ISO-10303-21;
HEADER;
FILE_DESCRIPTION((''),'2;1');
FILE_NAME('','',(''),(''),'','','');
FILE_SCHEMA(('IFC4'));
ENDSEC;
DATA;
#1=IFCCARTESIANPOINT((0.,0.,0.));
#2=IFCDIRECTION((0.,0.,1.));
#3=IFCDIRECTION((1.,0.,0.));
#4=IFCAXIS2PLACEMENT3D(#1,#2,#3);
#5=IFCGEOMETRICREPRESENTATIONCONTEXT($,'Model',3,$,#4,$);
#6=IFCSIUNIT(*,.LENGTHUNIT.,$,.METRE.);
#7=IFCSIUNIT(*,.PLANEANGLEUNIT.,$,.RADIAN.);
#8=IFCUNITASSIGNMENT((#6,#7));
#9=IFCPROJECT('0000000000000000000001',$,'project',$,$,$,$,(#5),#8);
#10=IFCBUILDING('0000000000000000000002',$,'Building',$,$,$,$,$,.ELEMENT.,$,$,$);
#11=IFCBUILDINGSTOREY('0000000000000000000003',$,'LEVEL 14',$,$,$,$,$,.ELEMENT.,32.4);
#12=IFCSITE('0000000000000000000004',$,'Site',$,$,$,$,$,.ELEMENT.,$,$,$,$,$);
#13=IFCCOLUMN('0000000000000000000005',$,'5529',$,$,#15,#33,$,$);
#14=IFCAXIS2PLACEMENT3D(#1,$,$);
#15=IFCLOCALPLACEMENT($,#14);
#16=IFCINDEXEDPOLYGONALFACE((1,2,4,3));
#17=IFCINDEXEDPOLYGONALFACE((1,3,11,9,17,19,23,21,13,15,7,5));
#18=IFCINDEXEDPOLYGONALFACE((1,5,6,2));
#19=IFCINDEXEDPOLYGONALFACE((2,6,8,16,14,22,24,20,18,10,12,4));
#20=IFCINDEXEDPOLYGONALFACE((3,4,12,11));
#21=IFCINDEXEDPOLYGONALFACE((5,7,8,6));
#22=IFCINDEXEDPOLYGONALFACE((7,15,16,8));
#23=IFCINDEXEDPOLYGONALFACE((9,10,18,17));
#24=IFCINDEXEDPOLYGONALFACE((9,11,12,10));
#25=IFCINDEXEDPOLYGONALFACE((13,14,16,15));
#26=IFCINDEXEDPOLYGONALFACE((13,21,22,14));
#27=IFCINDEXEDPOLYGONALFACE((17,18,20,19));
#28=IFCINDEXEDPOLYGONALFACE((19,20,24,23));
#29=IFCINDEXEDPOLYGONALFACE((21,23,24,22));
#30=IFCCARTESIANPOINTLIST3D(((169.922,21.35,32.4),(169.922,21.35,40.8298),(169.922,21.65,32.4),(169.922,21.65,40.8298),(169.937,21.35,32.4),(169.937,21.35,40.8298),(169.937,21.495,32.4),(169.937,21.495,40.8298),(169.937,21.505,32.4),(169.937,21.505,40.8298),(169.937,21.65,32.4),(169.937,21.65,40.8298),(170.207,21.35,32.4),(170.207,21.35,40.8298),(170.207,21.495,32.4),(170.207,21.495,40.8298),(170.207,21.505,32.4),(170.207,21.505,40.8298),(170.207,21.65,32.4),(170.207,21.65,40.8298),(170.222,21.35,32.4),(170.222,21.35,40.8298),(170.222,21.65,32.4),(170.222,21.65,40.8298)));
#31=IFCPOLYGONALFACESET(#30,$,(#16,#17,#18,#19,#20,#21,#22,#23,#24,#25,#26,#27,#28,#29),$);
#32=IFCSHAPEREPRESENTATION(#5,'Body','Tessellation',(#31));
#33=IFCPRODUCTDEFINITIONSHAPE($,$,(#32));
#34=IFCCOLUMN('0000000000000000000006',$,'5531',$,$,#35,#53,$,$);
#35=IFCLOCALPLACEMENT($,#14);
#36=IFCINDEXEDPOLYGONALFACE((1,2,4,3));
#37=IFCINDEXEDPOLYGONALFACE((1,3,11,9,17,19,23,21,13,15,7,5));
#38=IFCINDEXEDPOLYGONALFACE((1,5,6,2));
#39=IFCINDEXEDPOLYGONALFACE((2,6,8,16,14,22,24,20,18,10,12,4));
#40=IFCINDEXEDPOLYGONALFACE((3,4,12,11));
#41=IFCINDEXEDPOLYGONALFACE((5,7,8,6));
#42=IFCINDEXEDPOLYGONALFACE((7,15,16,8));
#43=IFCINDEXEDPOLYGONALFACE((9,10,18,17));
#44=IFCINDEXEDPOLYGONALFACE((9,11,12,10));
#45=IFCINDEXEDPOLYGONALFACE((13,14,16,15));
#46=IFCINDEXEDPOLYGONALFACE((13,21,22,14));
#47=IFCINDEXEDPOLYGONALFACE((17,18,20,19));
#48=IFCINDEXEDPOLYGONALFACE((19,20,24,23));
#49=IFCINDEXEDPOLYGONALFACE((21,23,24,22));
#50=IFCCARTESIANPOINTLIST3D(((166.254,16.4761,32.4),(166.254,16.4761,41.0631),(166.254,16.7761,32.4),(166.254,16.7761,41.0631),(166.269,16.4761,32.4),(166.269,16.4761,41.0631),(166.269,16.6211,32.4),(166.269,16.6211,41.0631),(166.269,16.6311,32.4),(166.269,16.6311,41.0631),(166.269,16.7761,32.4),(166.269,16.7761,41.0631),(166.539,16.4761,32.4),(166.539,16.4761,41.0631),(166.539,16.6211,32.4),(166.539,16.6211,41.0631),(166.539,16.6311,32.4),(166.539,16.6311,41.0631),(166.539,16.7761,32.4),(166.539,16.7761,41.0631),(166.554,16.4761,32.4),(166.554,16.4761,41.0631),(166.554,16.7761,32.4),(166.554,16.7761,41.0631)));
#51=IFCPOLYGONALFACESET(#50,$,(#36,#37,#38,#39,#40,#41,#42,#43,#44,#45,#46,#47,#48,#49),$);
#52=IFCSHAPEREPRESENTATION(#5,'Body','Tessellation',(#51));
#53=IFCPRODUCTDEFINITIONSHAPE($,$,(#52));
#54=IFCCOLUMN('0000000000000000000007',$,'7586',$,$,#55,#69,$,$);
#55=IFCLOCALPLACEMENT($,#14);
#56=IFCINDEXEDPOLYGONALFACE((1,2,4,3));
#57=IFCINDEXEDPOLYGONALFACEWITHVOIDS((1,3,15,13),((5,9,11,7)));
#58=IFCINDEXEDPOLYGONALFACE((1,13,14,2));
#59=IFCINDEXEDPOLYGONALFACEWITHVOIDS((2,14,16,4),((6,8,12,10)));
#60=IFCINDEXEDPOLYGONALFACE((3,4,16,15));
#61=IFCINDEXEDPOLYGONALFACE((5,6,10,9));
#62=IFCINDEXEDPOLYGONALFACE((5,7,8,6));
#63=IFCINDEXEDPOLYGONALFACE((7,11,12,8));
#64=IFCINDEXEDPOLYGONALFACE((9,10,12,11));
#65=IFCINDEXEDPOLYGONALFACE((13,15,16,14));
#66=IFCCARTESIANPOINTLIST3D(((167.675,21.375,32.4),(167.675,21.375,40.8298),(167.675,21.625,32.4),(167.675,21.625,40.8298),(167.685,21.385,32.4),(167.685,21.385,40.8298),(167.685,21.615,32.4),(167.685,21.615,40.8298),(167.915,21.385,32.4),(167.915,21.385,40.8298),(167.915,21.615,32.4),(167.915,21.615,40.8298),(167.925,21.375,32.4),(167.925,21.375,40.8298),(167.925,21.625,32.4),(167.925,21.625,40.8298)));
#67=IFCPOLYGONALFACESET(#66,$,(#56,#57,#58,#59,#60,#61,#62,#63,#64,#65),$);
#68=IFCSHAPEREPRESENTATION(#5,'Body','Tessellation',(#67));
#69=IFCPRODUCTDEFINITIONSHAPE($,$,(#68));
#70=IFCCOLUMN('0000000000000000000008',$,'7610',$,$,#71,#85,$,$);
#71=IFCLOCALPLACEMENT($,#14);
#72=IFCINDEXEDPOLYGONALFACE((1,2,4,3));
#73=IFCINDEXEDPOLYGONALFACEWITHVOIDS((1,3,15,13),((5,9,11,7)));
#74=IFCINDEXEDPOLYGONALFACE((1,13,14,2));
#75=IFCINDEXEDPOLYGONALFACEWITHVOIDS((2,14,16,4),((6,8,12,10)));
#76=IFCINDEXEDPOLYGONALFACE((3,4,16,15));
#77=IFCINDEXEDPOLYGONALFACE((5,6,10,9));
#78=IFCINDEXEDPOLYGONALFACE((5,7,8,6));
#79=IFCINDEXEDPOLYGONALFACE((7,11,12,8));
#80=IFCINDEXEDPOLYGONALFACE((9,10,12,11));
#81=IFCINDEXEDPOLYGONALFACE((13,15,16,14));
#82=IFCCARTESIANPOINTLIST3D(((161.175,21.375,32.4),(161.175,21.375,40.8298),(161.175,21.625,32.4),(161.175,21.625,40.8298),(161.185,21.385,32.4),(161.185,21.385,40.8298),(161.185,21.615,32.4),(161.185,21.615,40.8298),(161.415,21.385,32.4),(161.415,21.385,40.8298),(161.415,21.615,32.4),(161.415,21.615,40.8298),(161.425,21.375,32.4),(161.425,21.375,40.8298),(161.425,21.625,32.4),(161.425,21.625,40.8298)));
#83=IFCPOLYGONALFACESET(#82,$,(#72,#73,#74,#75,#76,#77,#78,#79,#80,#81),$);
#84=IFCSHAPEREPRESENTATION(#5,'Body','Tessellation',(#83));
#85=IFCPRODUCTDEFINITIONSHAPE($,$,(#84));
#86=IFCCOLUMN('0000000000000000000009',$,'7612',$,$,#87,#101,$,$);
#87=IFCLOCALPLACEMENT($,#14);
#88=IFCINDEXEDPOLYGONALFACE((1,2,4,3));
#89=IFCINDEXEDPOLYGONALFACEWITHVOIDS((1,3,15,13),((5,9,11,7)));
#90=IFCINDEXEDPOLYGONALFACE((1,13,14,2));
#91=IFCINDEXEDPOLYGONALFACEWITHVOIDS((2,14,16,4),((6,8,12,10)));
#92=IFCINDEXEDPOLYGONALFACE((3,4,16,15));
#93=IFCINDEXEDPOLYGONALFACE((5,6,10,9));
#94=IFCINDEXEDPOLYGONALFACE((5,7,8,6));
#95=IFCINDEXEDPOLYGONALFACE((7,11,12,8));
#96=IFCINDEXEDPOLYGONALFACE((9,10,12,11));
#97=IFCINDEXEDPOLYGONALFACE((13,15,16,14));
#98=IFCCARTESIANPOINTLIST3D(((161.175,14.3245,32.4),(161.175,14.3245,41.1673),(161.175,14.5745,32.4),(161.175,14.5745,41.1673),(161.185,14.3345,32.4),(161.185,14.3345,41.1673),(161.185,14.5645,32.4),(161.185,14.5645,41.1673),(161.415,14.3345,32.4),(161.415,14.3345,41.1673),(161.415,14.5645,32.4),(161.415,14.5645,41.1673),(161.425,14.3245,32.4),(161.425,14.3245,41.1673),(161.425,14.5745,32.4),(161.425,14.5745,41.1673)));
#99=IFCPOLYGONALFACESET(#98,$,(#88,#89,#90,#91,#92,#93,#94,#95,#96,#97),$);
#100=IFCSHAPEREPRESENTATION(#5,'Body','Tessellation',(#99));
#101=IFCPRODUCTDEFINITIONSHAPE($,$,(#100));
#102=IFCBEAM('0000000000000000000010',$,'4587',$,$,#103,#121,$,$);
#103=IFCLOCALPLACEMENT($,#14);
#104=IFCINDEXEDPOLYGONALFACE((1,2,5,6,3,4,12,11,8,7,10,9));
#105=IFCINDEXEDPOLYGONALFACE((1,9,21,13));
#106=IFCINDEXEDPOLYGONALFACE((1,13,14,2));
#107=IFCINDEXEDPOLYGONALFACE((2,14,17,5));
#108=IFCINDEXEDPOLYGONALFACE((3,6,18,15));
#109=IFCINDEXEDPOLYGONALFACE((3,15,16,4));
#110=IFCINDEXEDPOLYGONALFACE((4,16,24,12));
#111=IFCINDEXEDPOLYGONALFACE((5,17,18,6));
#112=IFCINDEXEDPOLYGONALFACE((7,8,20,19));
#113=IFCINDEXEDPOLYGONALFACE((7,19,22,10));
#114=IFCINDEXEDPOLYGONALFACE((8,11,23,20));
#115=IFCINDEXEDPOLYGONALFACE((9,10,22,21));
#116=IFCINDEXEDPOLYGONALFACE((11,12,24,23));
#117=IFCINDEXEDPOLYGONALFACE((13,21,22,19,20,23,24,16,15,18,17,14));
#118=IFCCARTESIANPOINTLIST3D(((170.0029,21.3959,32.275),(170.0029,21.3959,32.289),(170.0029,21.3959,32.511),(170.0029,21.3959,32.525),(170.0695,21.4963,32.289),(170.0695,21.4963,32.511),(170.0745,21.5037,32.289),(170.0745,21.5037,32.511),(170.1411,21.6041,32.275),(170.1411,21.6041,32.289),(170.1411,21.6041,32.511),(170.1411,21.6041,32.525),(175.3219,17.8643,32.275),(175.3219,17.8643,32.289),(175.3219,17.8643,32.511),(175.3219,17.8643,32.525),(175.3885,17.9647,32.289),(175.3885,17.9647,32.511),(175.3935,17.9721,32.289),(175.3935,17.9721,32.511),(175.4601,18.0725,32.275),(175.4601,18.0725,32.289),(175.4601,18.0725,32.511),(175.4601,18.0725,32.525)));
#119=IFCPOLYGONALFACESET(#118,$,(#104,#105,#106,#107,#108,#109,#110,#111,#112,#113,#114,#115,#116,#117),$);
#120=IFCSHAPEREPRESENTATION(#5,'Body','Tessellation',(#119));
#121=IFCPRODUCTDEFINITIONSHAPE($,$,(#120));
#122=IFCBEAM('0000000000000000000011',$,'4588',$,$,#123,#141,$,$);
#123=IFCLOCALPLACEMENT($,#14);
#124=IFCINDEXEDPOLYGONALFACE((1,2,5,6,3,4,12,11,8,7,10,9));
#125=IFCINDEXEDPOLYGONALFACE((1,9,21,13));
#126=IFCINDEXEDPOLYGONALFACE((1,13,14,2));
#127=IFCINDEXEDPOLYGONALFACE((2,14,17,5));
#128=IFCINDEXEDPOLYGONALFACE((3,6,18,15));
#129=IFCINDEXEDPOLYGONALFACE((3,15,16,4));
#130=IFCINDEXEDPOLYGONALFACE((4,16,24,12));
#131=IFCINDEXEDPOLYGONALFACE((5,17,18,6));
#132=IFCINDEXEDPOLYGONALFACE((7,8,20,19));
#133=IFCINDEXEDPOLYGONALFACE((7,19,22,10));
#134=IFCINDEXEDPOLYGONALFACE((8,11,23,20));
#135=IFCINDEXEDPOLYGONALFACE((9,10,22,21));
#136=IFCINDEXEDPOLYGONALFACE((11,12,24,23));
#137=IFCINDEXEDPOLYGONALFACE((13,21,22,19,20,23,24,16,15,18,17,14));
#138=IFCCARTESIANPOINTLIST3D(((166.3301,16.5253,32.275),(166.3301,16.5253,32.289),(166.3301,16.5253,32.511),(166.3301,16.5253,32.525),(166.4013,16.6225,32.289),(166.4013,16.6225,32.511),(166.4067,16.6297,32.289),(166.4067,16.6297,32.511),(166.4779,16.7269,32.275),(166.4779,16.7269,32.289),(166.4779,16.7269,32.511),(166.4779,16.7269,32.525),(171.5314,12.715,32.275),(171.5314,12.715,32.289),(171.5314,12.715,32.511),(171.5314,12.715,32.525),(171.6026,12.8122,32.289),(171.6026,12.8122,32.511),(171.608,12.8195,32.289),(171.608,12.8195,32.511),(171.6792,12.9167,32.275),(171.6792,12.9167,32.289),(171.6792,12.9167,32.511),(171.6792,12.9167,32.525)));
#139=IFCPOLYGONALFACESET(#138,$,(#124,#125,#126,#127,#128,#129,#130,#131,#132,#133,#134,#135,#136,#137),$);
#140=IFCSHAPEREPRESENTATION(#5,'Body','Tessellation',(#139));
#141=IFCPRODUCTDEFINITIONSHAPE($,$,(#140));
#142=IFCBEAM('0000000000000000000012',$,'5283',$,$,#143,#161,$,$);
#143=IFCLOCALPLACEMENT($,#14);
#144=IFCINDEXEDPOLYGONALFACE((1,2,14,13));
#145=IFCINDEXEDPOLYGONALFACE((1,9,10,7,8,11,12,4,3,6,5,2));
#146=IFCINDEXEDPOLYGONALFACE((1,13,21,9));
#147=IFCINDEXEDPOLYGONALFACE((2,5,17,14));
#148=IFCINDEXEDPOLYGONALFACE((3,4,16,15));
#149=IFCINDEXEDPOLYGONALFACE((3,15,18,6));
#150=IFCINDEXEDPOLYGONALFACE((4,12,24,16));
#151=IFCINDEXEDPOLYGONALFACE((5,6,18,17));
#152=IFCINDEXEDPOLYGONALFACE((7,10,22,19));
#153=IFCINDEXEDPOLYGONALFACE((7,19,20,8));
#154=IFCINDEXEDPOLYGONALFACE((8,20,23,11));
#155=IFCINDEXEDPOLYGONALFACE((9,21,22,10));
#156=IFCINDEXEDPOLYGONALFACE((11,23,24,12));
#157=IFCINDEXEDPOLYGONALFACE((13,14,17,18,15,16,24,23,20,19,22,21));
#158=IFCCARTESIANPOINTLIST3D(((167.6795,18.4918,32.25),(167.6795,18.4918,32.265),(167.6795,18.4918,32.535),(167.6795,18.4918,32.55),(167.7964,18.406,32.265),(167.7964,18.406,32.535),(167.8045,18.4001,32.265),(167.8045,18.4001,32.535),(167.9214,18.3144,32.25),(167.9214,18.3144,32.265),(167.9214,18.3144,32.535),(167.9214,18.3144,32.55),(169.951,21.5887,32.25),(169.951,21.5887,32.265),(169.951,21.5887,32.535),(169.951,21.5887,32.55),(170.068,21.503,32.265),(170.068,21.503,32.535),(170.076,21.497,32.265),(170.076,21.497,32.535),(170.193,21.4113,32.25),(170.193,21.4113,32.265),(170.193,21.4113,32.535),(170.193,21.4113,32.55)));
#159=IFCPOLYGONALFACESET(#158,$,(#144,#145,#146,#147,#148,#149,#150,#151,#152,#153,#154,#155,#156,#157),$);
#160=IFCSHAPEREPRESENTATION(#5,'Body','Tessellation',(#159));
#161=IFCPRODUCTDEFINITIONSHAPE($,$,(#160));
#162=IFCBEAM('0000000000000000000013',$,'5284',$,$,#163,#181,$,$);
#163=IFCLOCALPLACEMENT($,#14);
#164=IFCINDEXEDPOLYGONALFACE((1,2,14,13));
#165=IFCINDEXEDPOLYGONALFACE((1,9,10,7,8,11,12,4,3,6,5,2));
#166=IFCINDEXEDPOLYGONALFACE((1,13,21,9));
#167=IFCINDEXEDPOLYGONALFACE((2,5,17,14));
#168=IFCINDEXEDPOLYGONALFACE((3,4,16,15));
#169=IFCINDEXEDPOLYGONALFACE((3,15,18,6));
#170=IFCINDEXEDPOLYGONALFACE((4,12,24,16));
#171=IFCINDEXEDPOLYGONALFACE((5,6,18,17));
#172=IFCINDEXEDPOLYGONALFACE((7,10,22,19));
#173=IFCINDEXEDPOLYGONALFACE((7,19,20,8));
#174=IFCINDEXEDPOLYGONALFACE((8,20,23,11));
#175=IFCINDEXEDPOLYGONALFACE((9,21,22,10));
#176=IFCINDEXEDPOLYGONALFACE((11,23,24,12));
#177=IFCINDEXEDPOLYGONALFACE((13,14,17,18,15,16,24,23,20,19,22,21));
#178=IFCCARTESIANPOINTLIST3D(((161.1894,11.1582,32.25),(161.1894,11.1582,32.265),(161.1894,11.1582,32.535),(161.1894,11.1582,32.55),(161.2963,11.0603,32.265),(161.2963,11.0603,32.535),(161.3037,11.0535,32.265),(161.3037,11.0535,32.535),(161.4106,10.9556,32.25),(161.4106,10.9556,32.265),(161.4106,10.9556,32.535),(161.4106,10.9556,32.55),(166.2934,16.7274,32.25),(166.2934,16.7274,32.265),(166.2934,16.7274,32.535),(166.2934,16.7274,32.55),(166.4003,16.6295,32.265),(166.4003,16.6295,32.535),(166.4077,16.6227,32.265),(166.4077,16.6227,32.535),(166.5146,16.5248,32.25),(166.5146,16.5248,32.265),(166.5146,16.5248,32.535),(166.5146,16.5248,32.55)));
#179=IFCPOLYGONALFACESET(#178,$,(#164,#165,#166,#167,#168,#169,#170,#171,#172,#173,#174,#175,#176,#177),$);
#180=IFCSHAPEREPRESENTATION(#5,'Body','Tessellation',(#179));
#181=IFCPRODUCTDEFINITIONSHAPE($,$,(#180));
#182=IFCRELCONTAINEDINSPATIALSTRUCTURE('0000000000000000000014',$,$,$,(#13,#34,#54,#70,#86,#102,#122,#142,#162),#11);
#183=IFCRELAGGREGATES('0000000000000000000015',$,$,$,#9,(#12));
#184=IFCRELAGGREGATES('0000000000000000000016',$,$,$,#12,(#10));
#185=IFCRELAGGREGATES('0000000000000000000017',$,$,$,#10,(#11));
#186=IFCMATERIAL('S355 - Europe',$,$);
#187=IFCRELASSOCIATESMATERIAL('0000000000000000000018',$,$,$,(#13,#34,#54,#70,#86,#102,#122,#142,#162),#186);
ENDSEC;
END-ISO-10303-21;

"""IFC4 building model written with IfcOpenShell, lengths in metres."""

from ifc_helpers import new_model, si_unit, frame, origin_with_axes, origin_2d_with_axis, place, context, project, spatial, hollow_rectangle, i_section, extrude, material, material_profile, profile_set, profile_usage, element, save


model = new_model("IFC4")

# Units and contexts
model_context = context("Model", 3, world=origin_with_axes())
ifc_project = project(units=[si_unit("LENGTHUNIT", "METRE"), si_unit("PLANEANGLEUNIT", "RADIAN")], contexts=[model_context])

# Site, building, storey
site = spatial("IfcSite", under=ifc_project, Name="Site", CompositionType="ELEMENT")
building = spatial("IfcBuilding", under=site, Name="Building", CompositionType="ELEMENT")
storey = spatial("IfcBuildingStorey", under=building, Name="LEVEL 14", CompositionType="ELEMENT", Elevation=32.4)

# Columns
ifc_material = material(Name="S355 - Europe")
ifc_material_profile_1 = material_profile(ifc_material, i_section(OverallWidth=0.3, OverallDepth=0.3, WebThickness=0.01, FlangeThickness=0.015, at=origin_2d_with_axis()))
ifc_profile_set_1 = profile_set([ifc_material_profile_1])
ifc_profile_usage_1 = profile_usage(ifc_profile_set_1, cardinal=10)
column_1_placement = place(None, frame((170.072, 21.5, 32.4), z_axis=(0.0, 0.0, 1.0), x_axis=(0.0, -1.0, 0.0)))
element("IfcColumn", 1, at=column_1_placement, inside=storey, material=ifc_profile_usage_1, Name="5529", context=model_context, shape_type="SweptSolid", body=[
    extrude(i_section(OverallWidth=0.3, OverallDepth=0.3, WebThickness=0.01, FlangeThickness=0.015, at=origin_2d_with_axis()), origin_with_axes(), (0.0, 0.0, 1.0), 8.4298),
])
ifc_material_profile_2 = material_profile(ifc_material, i_section(OverallWidth=0.3, OverallDepth=0.3, WebThickness=0.01, FlangeThickness=0.015, at=origin_2d_with_axis()))
ifc_profile_set_2 = profile_set([ifc_material_profile_2])
ifc_profile_usage_2 = profile_usage(ifc_profile_set_2, cardinal=10)
column_2_placement = place(None, frame((166.404, 16.6261, 32.4), z_axis=(0.0, 0.0, 1.0), x_axis=(0.0, -1.0, 0.0)))
element("IfcColumn", 2, at=column_2_placement, inside=storey, material=ifc_profile_usage_2, Name="5531", context=model_context, shape_type="SweptSolid", body=[
    extrude(i_section(OverallWidth=0.3, OverallDepth=0.3, WebThickness=0.01, FlangeThickness=0.015, at=origin_2d_with_axis()), origin_with_axes(), (0.0, 0.0, 1.0), 8.6631),
])
ifc_material_profile_3 = material_profile(ifc_material, hollow_rectangle(XDim=0.25, YDim=0.25, WallThickness=0.01, at=origin_2d_with_axis()))
ifc_profile_set_3 = profile_set([ifc_material_profile_3])
ifc_profile_usage_3 = profile_usage(ifc_profile_set_3, cardinal=10)
column_3_placement = place(None, frame((167.8, 21.5, 32.4), z_axis=(0.0, 0.0, 1.0), x_axis=(0.0, -1.0, 0.0)))
element("IfcColumn", 3, at=column_3_placement, inside=storey, material=ifc_profile_usage_3, Name="7586", context=model_context, shape_type="SweptSolid", body=[
    extrude(hollow_rectangle(XDim=0.25, YDim=0.25, WallThickness=0.01, at=origin_2d_with_axis()), origin_with_axes(), (0.0, 0.0, 1.0), 8.4298),
])
ifc_material_profile_4 = material_profile(ifc_material, hollow_rectangle(XDim=0.25, YDim=0.25, WallThickness=0.01, at=origin_2d_with_axis()))
ifc_profile_set_4 = profile_set([ifc_material_profile_4])
ifc_profile_usage_4 = profile_usage(ifc_profile_set_4, cardinal=10)
column_4_placement = place(None, frame((161.3, 21.5, 32.4), z_axis=(0.0, 0.0, 1.0), x_axis=(0.0, -1.0, 0.0)))
element("IfcColumn", 4, at=column_4_placement, inside=storey, material=ifc_profile_usage_4, Name="7610", context=model_context, shape_type="SweptSolid", body=[
    extrude(hollow_rectangle(XDim=0.25, YDim=0.25, WallThickness=0.01, at=origin_2d_with_axis()), origin_with_axes(), (0.0, 0.0, 1.0), 8.4298),
])
ifc_material_profile_5 = material_profile(ifc_material, hollow_rectangle(XDim=0.25, YDim=0.25, WallThickness=0.01, at=origin_2d_with_axis()))
ifc_profile_set_5 = profile_set([ifc_material_profile_5])
ifc_profile_usage_5 = profile_usage(ifc_profile_set_5, cardinal=10)
column_5_placement = place(None, frame((161.3, 14.4495, 32.4), z_axis=(0.0, 0.0, 1.0), x_axis=(0.0, -1.0, 0.0)))
element("IfcColumn", 5, at=column_5_placement, inside=storey, material=ifc_profile_usage_5, Name="7612", context=model_context, shape_type="SweptSolid", body=[
    extrude(hollow_rectangle(XDim=0.25, YDim=0.25, WallThickness=0.01, at=origin_2d_with_axis()), origin_with_axes(), (0.0, 0.0, 1.0), 8.7673),
])

# Beams
ifc_material_profile_6 = material_profile(ifc_material, i_section(OverallWidth=0.25, OverallDepth=0.25, WebThickness=0.009, FlangeThickness=0.014, at=origin_2d_with_axis()))
ifc_profile_set_6 = profile_set([ifc_material_profile_6])
ifc_profile_usage_6 = profile_usage(ifc_profile_set_6, cardinal=10)
beam_1_placement = place(None, frame((170.072, 21.5, 32.4), z_axis=(0.83309, -0.553138, 0.0), x_axis=(0.553138, 0.83309, 0.0)))
element("IfcBeam", 6, at=beam_1_placement, inside=storey, material=ifc_profile_usage_6, Name="4587", context=model_context, shape_type="SweptSolid", body=[
    extrude(i_section(OverallWidth=0.25, OverallDepth=0.25, WebThickness=0.009, FlangeThickness=0.014, at=origin_2d_with_axis()), origin_with_axes(), (0.0, 0.0, 1.0), 6.3847),
])
ifc_material_profile_7 = material_profile(ifc_material, i_section(OverallWidth=0.25, OverallDepth=0.25, WebThickness=0.009, FlangeThickness=0.014, at=origin_2d_with_axis()))
ifc_profile_set_7 = profile_set([ifc_material_profile_7])
ifc_profile_usage_7 = profile_usage(ifc_profile_set_7, cardinal=10)
beam_2_placement = place(None, frame((166.404, 16.6261, 32.4), z_axis=(0.806706, -0.590953, 0.0), x_axis=(0.590953, 0.806706, 0.0)))
element("IfcBeam", 7, at=beam_2_placement, inside=storey, material=ifc_profile_usage_7, Name="4588", context=model_context, shape_type="SweptSolid", body=[
    extrude(i_section(OverallWidth=0.25, OverallDepth=0.25, WebThickness=0.009, FlangeThickness=0.014, at=origin_2d_with_axis()), origin_with_axes(), (0.0, 0.0, 1.0), 6.4476),
])
ifc_material_profile_8 = material_profile(ifc_material, i_section(OverallWidth=0.3, OverallDepth=0.3, WebThickness=0.01, FlangeThickness=0.015, at=origin_2d_with_axis()))
ifc_profile_set_8 = profile_set([ifc_material_profile_8])
ifc_profile_usage_8 = profile_usage(ifc_profile_set_8, cardinal=10)
beam_3_placement = place(None, frame((170.072, 21.5, 32.4), z_axis=(-0.591449, -0.806343, 0.0), x_axis=(0.806706, -0.590953, 0.0)))
element("IfcBeam", 8, at=beam_3_placement, inside=storey, material=ifc_profile_usage_8, Name="5283", context=model_context, shape_type="SweptSolid", body=[
    extrude(i_section(OverallWidth=0.3, OverallDepth=0.3, WebThickness=0.01, FlangeThickness=0.015, at=origin_2d_with_axis()), origin_with_axes(), (0.0, 0.0, 1.0), 3.8407),
])
ifc_material_profile_9 = material_profile(ifc_material, i_section(OverallWidth=0.3, OverallDepth=0.3, WebThickness=0.01, FlangeThickness=0.015, at=origin_2d_with_axis()))
ifc_profile_set_9 = profile_set([ifc_material_profile_9])
ifc_profile_usage_9 = profile_usage(ifc_profile_set_9, cardinal=10)
beam_4_placement = place(None, frame((166.404, 16.6261, 32.4), z_axis=(-0.675646, -0.737227, 0.0), x_axis=(0.737227, -0.675646, 0.0)))
element("IfcBeam", 9, at=beam_4_placement, inside=storey, material=ifc_profile_usage_9, Name="5284", context=model_context, shape_type="SweptSolid", body=[
    extrude(i_section(OverallWidth=0.3, OverallDepth=0.3, WebThickness=0.01, FlangeThickness=0.015, at=origin_2d_with_axis()), origin_with_axes(), (0.0, 0.0, 1.0), 7.5543),
])

save(model, "model.ifc")
